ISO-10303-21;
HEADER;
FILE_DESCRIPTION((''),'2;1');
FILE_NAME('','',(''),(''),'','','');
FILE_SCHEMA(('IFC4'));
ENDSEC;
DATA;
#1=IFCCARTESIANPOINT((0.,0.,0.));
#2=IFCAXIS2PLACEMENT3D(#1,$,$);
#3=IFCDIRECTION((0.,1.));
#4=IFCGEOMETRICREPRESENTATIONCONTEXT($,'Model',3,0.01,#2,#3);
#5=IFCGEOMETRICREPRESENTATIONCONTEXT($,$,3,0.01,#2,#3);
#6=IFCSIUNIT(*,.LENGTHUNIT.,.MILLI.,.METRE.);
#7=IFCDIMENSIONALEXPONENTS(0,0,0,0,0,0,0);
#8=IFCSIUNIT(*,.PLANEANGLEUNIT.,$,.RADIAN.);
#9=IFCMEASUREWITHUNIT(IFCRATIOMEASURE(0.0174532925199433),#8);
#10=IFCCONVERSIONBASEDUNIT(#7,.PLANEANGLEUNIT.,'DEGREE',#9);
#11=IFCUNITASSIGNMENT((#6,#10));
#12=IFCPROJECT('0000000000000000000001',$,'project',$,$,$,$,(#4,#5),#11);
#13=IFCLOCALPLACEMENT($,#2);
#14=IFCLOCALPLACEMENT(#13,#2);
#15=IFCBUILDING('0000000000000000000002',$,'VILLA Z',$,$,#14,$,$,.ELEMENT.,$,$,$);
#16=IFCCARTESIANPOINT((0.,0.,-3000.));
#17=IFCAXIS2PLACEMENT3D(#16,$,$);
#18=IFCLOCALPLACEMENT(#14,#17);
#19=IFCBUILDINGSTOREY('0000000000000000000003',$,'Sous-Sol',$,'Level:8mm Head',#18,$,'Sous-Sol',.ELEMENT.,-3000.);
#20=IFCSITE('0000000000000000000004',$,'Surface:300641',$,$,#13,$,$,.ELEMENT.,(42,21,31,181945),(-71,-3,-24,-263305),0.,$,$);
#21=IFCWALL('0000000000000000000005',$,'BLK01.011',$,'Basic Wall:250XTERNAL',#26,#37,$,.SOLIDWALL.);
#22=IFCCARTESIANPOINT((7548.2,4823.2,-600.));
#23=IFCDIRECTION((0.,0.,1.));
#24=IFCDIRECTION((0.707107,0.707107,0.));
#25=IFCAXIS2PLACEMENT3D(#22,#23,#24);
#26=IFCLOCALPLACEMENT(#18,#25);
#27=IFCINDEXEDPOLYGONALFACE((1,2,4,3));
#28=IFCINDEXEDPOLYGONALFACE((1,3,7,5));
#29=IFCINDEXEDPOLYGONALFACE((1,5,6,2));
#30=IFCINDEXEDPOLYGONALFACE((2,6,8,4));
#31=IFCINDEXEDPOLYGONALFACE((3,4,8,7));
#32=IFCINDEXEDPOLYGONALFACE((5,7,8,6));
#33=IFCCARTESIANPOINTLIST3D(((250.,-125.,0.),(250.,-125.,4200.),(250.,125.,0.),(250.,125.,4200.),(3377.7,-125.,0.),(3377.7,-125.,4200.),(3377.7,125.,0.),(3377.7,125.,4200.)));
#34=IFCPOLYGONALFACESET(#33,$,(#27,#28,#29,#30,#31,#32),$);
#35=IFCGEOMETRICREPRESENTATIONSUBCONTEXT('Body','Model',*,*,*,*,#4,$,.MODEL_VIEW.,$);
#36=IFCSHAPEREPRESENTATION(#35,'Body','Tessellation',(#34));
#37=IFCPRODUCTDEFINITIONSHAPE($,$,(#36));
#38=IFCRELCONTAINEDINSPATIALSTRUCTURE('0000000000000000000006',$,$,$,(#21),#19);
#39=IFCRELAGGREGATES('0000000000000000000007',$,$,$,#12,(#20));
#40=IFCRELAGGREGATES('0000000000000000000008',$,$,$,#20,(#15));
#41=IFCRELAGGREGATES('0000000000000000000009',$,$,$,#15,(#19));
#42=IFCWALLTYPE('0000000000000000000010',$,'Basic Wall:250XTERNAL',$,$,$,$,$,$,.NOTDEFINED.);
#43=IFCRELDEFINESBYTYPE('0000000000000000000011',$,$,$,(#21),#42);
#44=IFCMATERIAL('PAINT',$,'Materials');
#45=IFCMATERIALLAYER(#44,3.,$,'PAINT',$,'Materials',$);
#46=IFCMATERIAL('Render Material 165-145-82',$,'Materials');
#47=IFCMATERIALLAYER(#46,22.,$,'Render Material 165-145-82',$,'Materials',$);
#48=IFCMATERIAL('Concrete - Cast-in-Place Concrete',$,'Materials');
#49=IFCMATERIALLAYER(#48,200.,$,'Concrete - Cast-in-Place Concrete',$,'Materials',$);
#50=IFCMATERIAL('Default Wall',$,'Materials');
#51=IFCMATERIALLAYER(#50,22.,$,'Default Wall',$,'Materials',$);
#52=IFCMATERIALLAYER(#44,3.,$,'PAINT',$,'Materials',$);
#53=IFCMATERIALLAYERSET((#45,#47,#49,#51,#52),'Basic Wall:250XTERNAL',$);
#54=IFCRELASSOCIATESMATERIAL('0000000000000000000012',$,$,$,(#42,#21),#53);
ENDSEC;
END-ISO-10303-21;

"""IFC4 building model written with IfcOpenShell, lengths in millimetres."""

from ifc_helpers import new_model, entity, si_unit, converted_unit, direction, frame, frame_2d, origin, place, context, subcontext, project, spatial, rectangle, extrude, material, layer, layer_set, layer_usage, type_object, element, save


model = new_model("IFC4")

# Units and contexts
model_context = context("Model", 3, precision=0.01, world=origin(), true_north=direction((0.0, 1.0)))
context_of_model = context(None, 3, precision=0.01, world=origin(), true_north=direction((0.0, 1.0)))
body_context = subcontext(model_context, "Body", "Model", "MODEL_VIEW")
ifc_project = project(units=[si_unit("LENGTHUNIT", "METRE", prefix="MILLI"), converted_unit("PLANEANGLEUNIT", "DEGREE", entity("IfcRatioMeasure", 0.0174532925199433), si_unit("PLANEANGLEUNIT", "RADIAN"), dimensions=[0, 0, 0, 0, 0, 0, 0])], contexts=[model_context, context_of_model])

# Site, building, storey
site_placement = place(None, origin())
site = spatial("IfcSite", under=ifc_project, at=site_placement, Name="Surface:300641", CompositionType="ELEMENT", RefLatitude=(42, 21, 31, 181945), RefLongitude=(-71, -3, -24, -263305), RefElevation=0.0)
building_placement = place(site_placement, origin())
building = spatial("IfcBuilding", under=site, at=building_placement, Name="VILLA Z", CompositionType="ELEMENT")
storey_placement = place(building_placement, frame((0.0, 0.0, -3000.0)))
storey = spatial("IfcBuildingStorey", under=building, at=storey_placement, Name="Sous-Sol", ObjectType="Level:8mm Head", LongName="Sous-Sol", CompositionType="ELEMENT", Elevation=-3000.0)

# Shared definitions
ifc_material_1 = material(Name="Concrete - Cast-in-Place Concrete", Category="Materials")

# Wall
ifc_material_2 = material(Name="PAINT", Category="Materials")
ifc_layer_1 = layer(ifc_material_2, 3.0, Name="PAINT", Category="Materials")
ifc_material_3 = material(Name="Render Material 165-145-82", Category="Materials")
ifc_layer_2 = layer(ifc_material_3, 22.0, Name="Render Material 165-145-82", Category="Materials")
ifc_layer_3 = layer(ifc_material_1, 200.0, Name="Concrete - Cast-in-Place Concrete", Category="Materials")
ifc_material_4 = material(Name="Default Wall", Category="Materials")
ifc_layer_4 = layer(ifc_material_4, 22.0, Name="Default Wall", Category="Materials")
ifc_layer_5 = layer(ifc_material_2, 3.0, Name="PAINT", Category="Materials")
ifc_layer_set = layer_set([ifc_layer_1, ifc_layer_2, ifc_layer_3, ifc_layer_4, ifc_layer_5], Name="Basic Wall:250XTERNAL")
wall_type = type_object("IfcWallType", Name="Basic Wall:250XTERNAL", PredefinedType="NOTDEFINED", material=ifc_layer_set)
ifc_layer_usage_1 = layer_usage(ifc_layer_set, "AXIS2", "POSITIVE", -125.0)
wall_1_placement = place(storey_placement, frame((7548.2, 4823.2, -600.0), z_axis=(0.0, 0.0, 1.0), x_axis=(0.707107, 0.707107, 0.0)))
element("IfcWall", 1, at=wall_1_placement, inside=storey, type_object=wall_type, material=ifc_layer_usage_1, Name="BLK01.011", ObjectType="Basic Wall:250XTERNAL", PredefinedType="SOLIDWALL", context=body_context, shape_type="SweptSolid", body=[
    extrude(rectangle(XDim=3127.7, YDim=250.0, at=frame_2d((1813.8, 0.0), x_axis=(-1.0, 0.0))), origin(), (0.0, 0.0, 1.0), 4200.0),
])

save(model, "model.ifc")
